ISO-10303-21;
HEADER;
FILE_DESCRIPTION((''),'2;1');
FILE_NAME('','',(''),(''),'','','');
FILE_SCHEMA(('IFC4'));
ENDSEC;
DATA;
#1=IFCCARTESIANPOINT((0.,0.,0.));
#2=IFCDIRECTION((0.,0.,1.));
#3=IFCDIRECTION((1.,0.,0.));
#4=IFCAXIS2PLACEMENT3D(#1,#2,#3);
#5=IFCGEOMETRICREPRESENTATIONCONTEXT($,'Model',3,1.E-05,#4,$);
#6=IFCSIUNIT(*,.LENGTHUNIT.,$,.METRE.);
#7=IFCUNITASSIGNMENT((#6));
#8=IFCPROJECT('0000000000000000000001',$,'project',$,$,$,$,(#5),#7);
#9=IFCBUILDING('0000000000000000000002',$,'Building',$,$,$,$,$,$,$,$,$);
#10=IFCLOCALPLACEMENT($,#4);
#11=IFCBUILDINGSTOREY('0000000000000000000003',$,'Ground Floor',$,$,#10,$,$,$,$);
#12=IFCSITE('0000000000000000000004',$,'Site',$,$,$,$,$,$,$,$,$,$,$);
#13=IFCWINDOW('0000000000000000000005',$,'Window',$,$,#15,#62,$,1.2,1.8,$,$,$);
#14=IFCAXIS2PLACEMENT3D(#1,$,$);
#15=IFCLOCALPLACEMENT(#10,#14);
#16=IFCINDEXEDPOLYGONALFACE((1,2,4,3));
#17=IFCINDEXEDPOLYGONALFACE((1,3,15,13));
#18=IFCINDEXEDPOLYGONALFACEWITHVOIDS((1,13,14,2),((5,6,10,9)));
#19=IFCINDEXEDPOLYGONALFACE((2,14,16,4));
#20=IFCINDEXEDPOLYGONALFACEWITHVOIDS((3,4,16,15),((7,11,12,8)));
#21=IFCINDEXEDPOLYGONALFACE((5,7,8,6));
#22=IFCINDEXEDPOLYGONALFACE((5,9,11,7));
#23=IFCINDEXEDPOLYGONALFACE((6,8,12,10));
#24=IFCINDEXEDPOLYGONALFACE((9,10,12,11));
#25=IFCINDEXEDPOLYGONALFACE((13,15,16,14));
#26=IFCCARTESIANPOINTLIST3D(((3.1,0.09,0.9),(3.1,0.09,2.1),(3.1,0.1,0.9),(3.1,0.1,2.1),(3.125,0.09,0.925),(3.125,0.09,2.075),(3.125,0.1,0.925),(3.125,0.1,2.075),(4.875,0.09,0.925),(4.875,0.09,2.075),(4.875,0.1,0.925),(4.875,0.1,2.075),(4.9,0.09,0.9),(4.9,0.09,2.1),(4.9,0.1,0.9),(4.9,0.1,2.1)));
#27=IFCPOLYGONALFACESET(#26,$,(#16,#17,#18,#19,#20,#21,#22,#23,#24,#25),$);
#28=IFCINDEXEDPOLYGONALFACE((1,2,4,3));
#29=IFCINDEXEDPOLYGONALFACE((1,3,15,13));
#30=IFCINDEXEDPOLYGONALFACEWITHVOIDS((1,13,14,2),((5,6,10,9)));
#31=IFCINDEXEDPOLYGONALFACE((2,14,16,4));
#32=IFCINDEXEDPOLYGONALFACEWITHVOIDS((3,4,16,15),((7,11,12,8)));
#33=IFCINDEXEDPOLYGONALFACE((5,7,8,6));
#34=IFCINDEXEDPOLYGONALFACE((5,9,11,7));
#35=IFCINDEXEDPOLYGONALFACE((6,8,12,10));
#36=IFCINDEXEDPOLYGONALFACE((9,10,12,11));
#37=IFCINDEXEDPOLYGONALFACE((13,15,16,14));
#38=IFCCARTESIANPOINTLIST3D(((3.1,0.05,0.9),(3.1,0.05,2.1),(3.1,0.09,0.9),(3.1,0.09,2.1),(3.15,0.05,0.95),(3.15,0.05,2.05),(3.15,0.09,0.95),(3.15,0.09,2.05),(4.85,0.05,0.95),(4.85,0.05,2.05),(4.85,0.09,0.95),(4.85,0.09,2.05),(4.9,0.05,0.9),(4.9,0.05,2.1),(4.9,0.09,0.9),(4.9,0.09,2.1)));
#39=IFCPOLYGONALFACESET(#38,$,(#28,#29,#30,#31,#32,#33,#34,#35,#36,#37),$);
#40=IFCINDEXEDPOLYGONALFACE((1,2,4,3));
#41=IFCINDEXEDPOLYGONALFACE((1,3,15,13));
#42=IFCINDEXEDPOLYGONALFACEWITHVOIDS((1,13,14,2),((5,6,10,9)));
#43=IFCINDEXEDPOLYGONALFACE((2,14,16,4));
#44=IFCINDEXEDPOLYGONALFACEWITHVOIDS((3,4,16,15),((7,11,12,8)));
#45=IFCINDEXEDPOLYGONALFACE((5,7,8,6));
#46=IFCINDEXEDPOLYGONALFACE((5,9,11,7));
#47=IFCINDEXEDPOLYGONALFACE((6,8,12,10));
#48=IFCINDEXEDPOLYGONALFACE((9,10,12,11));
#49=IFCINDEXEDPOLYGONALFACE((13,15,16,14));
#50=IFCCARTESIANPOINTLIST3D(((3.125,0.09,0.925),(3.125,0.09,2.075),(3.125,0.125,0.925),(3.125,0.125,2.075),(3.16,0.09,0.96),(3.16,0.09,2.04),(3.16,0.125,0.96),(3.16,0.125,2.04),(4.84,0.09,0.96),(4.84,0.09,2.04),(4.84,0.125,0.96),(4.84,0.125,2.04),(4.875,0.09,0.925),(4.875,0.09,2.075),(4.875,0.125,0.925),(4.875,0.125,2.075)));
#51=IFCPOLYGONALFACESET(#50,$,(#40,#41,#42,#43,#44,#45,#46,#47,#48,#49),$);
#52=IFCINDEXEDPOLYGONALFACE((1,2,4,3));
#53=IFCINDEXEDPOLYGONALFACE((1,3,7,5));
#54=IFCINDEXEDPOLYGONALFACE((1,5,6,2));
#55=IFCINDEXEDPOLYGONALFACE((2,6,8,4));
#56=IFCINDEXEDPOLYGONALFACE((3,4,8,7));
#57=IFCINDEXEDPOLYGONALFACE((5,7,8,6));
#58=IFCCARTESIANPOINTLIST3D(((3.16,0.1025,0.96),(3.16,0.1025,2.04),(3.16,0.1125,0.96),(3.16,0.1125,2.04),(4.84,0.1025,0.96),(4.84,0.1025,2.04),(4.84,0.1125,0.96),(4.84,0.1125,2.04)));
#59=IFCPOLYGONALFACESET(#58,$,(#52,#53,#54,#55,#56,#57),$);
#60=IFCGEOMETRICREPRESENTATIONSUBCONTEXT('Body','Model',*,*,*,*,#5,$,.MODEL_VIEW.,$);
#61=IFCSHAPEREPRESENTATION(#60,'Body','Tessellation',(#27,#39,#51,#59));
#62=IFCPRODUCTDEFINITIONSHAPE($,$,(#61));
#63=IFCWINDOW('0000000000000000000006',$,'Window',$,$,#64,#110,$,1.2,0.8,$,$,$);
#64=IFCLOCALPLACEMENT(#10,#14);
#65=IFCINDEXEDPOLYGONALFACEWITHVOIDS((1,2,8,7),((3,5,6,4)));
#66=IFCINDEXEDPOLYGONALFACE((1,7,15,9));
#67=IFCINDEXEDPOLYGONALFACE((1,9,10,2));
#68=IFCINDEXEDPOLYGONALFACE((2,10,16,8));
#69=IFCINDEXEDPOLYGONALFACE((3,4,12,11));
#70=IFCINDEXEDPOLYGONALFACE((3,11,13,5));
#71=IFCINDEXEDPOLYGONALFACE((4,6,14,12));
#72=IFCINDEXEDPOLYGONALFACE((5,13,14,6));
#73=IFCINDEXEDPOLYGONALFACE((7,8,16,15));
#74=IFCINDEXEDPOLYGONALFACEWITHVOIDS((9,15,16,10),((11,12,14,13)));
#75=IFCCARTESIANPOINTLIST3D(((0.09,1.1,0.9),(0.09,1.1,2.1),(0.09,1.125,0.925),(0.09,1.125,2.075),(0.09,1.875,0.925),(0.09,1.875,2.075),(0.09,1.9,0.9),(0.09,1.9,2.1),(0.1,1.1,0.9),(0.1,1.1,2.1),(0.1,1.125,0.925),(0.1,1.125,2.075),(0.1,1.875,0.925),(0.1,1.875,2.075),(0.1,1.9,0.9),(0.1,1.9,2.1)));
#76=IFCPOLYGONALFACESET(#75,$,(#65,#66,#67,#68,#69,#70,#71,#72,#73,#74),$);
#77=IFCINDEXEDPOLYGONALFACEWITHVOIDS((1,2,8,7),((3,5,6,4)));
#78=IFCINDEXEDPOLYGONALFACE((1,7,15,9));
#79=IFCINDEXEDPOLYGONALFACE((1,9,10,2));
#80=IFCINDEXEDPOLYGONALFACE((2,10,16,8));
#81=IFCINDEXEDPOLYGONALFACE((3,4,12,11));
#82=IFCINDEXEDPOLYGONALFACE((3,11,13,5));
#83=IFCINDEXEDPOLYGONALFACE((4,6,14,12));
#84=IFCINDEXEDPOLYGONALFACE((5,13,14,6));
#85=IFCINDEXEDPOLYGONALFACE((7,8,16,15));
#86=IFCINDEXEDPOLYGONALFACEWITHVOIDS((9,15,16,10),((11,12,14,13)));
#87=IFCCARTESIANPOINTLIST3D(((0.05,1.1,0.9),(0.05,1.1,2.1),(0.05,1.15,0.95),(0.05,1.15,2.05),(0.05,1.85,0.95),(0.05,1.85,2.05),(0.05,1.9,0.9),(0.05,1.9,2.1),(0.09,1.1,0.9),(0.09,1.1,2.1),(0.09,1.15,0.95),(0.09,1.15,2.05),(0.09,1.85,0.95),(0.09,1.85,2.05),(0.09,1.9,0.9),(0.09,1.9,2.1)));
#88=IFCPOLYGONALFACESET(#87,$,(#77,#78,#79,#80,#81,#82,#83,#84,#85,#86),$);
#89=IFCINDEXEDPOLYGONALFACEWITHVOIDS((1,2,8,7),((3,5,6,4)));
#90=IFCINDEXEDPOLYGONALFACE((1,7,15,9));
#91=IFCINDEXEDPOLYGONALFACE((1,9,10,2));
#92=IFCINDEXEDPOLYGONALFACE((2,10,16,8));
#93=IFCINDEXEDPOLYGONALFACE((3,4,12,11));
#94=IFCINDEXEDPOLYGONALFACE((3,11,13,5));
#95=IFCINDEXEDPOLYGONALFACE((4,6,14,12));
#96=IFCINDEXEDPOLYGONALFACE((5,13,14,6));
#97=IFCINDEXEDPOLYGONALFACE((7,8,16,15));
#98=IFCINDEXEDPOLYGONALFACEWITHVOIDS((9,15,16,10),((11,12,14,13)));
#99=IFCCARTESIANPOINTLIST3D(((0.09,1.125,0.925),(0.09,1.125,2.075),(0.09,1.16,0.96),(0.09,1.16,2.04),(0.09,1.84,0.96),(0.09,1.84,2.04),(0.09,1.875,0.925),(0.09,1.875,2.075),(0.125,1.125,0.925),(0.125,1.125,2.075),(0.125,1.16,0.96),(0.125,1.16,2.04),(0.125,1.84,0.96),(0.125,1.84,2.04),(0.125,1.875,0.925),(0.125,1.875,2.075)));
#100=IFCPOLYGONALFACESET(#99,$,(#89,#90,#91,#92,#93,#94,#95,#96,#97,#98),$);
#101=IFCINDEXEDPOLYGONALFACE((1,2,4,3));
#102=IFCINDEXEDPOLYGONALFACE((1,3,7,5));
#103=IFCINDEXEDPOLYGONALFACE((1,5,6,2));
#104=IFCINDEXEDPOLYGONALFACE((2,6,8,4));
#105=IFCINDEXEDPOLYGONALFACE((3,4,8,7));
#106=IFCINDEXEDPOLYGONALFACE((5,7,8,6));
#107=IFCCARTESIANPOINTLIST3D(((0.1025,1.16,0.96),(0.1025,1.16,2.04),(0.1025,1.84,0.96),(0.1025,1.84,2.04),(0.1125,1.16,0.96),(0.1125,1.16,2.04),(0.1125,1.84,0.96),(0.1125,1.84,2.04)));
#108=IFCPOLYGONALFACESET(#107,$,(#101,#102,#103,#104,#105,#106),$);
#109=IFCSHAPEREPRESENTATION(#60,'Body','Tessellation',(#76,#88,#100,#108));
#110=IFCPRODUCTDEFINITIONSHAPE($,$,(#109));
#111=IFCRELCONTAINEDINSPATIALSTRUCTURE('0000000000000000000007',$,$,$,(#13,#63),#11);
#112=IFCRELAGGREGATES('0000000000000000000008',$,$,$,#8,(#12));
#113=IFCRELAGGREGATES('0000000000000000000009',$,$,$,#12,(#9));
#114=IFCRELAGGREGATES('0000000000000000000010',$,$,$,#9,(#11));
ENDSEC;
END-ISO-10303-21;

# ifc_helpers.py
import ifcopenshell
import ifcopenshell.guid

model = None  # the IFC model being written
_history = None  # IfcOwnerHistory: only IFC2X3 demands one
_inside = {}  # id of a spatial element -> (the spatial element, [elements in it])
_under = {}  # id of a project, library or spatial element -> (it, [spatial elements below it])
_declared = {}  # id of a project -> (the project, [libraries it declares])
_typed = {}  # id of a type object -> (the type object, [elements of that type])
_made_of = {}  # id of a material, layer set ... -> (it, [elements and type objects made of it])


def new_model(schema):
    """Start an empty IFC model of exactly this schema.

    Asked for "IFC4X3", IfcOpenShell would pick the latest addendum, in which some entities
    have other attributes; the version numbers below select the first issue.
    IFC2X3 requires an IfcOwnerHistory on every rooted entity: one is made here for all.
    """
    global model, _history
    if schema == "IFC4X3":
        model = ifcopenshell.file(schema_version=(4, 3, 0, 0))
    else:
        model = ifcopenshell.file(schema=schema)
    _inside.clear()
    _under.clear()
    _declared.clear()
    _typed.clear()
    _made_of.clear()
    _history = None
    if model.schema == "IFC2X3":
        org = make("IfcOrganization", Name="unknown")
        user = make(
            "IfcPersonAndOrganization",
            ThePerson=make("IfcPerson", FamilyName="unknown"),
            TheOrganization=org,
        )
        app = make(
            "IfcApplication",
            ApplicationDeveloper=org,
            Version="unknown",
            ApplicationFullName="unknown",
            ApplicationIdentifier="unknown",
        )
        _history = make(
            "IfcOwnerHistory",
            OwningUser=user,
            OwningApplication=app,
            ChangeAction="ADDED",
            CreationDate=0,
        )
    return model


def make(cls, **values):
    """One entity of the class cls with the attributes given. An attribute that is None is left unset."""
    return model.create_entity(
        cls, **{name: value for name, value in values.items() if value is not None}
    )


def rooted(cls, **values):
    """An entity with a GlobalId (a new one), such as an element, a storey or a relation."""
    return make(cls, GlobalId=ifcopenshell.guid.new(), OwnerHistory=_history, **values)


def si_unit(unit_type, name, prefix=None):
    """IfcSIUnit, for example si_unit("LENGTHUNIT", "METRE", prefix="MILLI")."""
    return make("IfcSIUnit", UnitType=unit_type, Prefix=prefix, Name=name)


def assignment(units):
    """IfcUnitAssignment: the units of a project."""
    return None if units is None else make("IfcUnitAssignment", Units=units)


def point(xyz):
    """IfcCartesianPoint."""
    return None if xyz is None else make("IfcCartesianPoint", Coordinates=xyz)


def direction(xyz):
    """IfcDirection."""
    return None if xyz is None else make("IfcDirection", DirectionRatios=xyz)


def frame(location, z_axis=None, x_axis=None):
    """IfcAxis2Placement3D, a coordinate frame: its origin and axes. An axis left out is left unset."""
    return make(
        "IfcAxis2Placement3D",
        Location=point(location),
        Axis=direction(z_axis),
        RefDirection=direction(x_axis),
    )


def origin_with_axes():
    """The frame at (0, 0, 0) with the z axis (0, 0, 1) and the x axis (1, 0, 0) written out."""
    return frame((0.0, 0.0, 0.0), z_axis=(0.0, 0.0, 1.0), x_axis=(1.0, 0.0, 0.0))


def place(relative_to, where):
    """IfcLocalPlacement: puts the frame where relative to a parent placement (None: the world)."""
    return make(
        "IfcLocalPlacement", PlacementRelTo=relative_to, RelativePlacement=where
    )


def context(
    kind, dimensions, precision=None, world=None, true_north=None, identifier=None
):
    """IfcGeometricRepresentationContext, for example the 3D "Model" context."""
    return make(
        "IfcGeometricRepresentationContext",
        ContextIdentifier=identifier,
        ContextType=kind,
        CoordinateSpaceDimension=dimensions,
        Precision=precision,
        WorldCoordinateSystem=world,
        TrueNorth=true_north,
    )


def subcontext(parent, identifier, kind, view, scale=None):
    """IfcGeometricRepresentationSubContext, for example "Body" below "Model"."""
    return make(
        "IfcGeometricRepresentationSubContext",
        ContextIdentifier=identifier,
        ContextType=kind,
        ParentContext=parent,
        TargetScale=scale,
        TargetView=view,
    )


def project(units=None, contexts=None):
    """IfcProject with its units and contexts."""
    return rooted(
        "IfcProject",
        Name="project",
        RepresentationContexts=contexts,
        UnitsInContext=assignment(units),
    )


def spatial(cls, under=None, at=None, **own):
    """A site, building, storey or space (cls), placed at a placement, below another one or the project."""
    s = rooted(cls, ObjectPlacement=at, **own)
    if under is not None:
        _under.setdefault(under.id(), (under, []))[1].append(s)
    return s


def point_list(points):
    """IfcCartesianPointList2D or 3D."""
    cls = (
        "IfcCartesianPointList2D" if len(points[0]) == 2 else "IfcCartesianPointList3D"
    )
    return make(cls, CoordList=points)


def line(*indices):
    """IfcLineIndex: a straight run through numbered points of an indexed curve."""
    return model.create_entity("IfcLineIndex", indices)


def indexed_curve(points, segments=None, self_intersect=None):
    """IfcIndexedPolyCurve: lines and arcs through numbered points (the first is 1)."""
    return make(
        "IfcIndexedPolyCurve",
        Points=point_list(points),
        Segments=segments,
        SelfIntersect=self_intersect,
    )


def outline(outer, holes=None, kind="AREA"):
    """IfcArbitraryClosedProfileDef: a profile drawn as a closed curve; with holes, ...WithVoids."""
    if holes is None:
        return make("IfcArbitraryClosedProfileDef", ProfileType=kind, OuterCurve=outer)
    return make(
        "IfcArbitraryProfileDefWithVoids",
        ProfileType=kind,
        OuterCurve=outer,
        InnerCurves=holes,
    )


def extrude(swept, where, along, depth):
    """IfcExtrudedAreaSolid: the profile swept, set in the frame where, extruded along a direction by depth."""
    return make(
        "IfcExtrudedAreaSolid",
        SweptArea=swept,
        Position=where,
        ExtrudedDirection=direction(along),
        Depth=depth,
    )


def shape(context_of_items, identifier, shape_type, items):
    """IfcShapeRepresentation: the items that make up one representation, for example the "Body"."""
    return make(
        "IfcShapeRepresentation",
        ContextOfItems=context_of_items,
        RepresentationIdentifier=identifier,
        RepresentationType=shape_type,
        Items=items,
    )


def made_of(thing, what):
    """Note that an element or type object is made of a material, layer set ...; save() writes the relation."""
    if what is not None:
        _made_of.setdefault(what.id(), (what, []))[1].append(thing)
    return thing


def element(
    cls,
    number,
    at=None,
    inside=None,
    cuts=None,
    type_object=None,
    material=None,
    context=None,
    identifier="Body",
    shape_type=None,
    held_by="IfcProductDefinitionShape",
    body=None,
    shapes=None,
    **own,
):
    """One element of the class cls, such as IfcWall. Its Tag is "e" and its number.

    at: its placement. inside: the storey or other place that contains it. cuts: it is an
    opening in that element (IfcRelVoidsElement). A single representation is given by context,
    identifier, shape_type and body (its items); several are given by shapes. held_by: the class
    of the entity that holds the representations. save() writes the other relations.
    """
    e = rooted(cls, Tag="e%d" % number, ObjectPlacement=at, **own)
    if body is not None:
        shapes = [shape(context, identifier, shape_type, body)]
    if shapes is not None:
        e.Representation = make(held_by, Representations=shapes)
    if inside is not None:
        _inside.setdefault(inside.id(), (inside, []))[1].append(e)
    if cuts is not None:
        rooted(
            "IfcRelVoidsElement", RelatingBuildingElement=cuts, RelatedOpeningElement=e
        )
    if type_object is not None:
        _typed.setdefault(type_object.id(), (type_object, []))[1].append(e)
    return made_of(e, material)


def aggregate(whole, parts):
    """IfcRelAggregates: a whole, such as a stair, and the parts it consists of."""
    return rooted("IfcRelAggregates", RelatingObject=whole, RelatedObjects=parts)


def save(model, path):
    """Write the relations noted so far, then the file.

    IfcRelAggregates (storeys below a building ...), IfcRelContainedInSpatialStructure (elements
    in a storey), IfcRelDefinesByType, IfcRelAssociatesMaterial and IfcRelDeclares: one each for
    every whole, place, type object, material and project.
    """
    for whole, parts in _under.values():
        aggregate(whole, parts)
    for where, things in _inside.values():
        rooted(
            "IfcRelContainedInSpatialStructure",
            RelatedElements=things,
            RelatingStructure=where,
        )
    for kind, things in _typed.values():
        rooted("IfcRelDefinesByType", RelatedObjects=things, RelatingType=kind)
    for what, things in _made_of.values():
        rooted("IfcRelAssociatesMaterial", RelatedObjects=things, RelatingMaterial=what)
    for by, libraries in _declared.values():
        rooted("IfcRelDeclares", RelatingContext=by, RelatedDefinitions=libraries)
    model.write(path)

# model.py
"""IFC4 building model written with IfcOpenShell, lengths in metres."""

from ifc_helpers import new_model, si_unit, frame, origin_with_axes, place, context, subcontext, project, spatial, line, indexed_curve, outline, extrude, element, save


model = new_model("IFC4")

# Units and contexts
model_context = context("Model", 3, precision=1e-05, world=origin_with_axes())
body_context = subcontext(model_context, "Body", "Model", "MODEL_VIEW")
ifc_project = project(units=[si_unit("LENGTHUNIT", "METRE")], contexts=[model_context])

# Site, building, storey
site = spatial("IfcSite", under=ifc_project, Name="Site")
building = spatial("IfcBuilding", under=site, Name="Building")
storey_placement = place(None, origin_with_axes())
storey = spatial("IfcBuildingStorey", under=building, at=storey_placement, Name="Ground Floor")

# Windows
window_1_placement = place(storey_placement, frame((3.1, 0.0, 0.9), z_axis=(0.0, 0.0, 1.0), x_axis=(1.0, 0.0, 0.0)))
element("IfcWindow", 1, at=window_1_placement, inside=storey, Name="Window", OverallHeight=1.2, OverallWidth=1.8, context=body_context, shape_type="SweptSolid", body=[
    extrude(outline(indexed_curve([(0.0, 0.0), (1.8, 0.0), (1.8, 1.2), (0.0, 1.2)], segments=[line(1, 2, 3, 4, 1)]), holes=[indexed_curve([(0.025, 0.025), (1.775, 0.025), (1.775, 1.175), (0.025, 1.175)], segments=[line(1, 2, 3, 4, 1)])]), frame((0.0, 0.09, 0.0), z_axis=(0.0, -1.0, 0.0), x_axis=(1.0, 0.0, 0.0)), (0.0, 0.0, -1.0), 0.01),
    extrude(outline(indexed_curve([(0.0, 0.0), (1.8, 0.0), (1.8, 1.2), (0.0, 1.2)], segments=[line(1, 2, 3, 4, 1)]), holes=[indexed_curve([(0.05, 0.05), (1.75, 0.05), (1.75, 1.15), (0.05, 1.15)], segments=[line(1, 2, 3, 4, 1)])]), frame((0.0, 0.05, 0.0), z_axis=(0.0, -1.0, 0.0), x_axis=(1.0, 0.0, 0.0)), (0.0, 0.0, -1.0), 0.04),
    extrude(outline(indexed_curve([(0.0, 0.0), (1.75, 0.0), (1.75, 1.15), (0.0, 1.15)], segments=[line(1, 2, 3, 4, 1)]), holes=[indexed_curve([(0.035, 0.035), (1.715, 0.035), (1.715, 1.115), (0.035, 1.115)], segments=[line(1, 2, 3, 4, 1)])]), frame((0.025, 0.09, 0.025), z_axis=(0.0, -1.0, 0.0), x_axis=(1.0, 0.0, 0.0)), (0.0, 0.0, -1.0), 0.035),
    extrude(outline(indexed_curve([(0.035, 0.035), (1.715, 0.035), (1.715, 1.115), (0.035, 1.115)], segments=[line(1, 2, 3, 4, 1)])), frame((0.025, 0.1025, 0.025), z_axis=(0.0, -1.0, 0.0), x_axis=(1.0, 0.0, 0.0)), (0.0, 0.0, -1.0), 0.01),
])
window_2_placement = place(storey_placement, frame((0.0, 1.9, 0.9), z_axis=(0.0, 0.0, 1.0), x_axis=(0.0, -1.0, 0.0)))
element("IfcWindow", 2, at=window_2_placement, inside=storey, Name="Window", OverallHeight=1.2, OverallWidth=0.8, context=body_context, shape_type="SweptSolid", body=[
    extrude(outline(indexed_curve([(0.0, 0.0), (0.8, 0.0), (0.8, 1.2), (0.0, 1.2)], segments=[line(1, 2, 3, 4, 1)]), holes=[indexed_curve([(0.025, 0.025), (0.775, 0.025), (0.775, 1.175), (0.025, 1.175)], segments=[line(1, 2, 3, 4, 1)])]), frame((0.0, 0.09, 0.0), z_axis=(0.0, -1.0, 0.0), x_axis=(1.0, 0.0, 0.0)), (0.0, 0.0, -1.0), 0.01),
    extrude(outline(indexed_curve([(0.0, 0.0), (0.8, 0.0), (0.8, 1.2), (0.0, 1.2)], segments=[line(1, 2, 3, 4, 1)]), holes=[indexed_curve([(0.05, 0.05), (0.75, 0.05), (0.75, 1.15), (0.05, 1.15)], segments=[line(1, 2, 3, 4, 1)])]), frame((0.0, 0.05, 0.0), z_axis=(0.0, -1.0, 0.0), x_axis=(1.0, 0.0, 0.0)), (0.0, 0.0, -1.0), 0.04),
    extrude(outline(indexed_curve([(0.0, 0.0), (0.75, 0.0), (0.75, 1.15), (0.0, 1.15)], segments=[line(1, 2, 3, 4, 1)]), holes=[indexed_curve([(0.035, 0.035), (0.715, 0.035), (0.715, 1.115), (0.035, 1.115)], segments=[line(1, 2, 3, 4, 1)])]), frame((0.025, 0.09, 0.025), z_axis=(0.0, -1.0, 0.0), x_axis=(1.0, 0.0, 0.0)), (0.0, 0.0, -1.0), 0.035),
    extrude(outline(indexed_curve([(0.035, 0.035), (0.715, 0.035), (0.715, 1.115), (0.035, 1.115)], segments=[line(1, 2, 3, 4, 1)])), frame((0.025, 0.1025, 0.025), z_axis=(0.0, -1.0, 0.0), x_axis=(1.0, 0.0, 0.0)), (0.0, 0.0, -1.0), 0.01),
])

save(model, "model.ifc")
